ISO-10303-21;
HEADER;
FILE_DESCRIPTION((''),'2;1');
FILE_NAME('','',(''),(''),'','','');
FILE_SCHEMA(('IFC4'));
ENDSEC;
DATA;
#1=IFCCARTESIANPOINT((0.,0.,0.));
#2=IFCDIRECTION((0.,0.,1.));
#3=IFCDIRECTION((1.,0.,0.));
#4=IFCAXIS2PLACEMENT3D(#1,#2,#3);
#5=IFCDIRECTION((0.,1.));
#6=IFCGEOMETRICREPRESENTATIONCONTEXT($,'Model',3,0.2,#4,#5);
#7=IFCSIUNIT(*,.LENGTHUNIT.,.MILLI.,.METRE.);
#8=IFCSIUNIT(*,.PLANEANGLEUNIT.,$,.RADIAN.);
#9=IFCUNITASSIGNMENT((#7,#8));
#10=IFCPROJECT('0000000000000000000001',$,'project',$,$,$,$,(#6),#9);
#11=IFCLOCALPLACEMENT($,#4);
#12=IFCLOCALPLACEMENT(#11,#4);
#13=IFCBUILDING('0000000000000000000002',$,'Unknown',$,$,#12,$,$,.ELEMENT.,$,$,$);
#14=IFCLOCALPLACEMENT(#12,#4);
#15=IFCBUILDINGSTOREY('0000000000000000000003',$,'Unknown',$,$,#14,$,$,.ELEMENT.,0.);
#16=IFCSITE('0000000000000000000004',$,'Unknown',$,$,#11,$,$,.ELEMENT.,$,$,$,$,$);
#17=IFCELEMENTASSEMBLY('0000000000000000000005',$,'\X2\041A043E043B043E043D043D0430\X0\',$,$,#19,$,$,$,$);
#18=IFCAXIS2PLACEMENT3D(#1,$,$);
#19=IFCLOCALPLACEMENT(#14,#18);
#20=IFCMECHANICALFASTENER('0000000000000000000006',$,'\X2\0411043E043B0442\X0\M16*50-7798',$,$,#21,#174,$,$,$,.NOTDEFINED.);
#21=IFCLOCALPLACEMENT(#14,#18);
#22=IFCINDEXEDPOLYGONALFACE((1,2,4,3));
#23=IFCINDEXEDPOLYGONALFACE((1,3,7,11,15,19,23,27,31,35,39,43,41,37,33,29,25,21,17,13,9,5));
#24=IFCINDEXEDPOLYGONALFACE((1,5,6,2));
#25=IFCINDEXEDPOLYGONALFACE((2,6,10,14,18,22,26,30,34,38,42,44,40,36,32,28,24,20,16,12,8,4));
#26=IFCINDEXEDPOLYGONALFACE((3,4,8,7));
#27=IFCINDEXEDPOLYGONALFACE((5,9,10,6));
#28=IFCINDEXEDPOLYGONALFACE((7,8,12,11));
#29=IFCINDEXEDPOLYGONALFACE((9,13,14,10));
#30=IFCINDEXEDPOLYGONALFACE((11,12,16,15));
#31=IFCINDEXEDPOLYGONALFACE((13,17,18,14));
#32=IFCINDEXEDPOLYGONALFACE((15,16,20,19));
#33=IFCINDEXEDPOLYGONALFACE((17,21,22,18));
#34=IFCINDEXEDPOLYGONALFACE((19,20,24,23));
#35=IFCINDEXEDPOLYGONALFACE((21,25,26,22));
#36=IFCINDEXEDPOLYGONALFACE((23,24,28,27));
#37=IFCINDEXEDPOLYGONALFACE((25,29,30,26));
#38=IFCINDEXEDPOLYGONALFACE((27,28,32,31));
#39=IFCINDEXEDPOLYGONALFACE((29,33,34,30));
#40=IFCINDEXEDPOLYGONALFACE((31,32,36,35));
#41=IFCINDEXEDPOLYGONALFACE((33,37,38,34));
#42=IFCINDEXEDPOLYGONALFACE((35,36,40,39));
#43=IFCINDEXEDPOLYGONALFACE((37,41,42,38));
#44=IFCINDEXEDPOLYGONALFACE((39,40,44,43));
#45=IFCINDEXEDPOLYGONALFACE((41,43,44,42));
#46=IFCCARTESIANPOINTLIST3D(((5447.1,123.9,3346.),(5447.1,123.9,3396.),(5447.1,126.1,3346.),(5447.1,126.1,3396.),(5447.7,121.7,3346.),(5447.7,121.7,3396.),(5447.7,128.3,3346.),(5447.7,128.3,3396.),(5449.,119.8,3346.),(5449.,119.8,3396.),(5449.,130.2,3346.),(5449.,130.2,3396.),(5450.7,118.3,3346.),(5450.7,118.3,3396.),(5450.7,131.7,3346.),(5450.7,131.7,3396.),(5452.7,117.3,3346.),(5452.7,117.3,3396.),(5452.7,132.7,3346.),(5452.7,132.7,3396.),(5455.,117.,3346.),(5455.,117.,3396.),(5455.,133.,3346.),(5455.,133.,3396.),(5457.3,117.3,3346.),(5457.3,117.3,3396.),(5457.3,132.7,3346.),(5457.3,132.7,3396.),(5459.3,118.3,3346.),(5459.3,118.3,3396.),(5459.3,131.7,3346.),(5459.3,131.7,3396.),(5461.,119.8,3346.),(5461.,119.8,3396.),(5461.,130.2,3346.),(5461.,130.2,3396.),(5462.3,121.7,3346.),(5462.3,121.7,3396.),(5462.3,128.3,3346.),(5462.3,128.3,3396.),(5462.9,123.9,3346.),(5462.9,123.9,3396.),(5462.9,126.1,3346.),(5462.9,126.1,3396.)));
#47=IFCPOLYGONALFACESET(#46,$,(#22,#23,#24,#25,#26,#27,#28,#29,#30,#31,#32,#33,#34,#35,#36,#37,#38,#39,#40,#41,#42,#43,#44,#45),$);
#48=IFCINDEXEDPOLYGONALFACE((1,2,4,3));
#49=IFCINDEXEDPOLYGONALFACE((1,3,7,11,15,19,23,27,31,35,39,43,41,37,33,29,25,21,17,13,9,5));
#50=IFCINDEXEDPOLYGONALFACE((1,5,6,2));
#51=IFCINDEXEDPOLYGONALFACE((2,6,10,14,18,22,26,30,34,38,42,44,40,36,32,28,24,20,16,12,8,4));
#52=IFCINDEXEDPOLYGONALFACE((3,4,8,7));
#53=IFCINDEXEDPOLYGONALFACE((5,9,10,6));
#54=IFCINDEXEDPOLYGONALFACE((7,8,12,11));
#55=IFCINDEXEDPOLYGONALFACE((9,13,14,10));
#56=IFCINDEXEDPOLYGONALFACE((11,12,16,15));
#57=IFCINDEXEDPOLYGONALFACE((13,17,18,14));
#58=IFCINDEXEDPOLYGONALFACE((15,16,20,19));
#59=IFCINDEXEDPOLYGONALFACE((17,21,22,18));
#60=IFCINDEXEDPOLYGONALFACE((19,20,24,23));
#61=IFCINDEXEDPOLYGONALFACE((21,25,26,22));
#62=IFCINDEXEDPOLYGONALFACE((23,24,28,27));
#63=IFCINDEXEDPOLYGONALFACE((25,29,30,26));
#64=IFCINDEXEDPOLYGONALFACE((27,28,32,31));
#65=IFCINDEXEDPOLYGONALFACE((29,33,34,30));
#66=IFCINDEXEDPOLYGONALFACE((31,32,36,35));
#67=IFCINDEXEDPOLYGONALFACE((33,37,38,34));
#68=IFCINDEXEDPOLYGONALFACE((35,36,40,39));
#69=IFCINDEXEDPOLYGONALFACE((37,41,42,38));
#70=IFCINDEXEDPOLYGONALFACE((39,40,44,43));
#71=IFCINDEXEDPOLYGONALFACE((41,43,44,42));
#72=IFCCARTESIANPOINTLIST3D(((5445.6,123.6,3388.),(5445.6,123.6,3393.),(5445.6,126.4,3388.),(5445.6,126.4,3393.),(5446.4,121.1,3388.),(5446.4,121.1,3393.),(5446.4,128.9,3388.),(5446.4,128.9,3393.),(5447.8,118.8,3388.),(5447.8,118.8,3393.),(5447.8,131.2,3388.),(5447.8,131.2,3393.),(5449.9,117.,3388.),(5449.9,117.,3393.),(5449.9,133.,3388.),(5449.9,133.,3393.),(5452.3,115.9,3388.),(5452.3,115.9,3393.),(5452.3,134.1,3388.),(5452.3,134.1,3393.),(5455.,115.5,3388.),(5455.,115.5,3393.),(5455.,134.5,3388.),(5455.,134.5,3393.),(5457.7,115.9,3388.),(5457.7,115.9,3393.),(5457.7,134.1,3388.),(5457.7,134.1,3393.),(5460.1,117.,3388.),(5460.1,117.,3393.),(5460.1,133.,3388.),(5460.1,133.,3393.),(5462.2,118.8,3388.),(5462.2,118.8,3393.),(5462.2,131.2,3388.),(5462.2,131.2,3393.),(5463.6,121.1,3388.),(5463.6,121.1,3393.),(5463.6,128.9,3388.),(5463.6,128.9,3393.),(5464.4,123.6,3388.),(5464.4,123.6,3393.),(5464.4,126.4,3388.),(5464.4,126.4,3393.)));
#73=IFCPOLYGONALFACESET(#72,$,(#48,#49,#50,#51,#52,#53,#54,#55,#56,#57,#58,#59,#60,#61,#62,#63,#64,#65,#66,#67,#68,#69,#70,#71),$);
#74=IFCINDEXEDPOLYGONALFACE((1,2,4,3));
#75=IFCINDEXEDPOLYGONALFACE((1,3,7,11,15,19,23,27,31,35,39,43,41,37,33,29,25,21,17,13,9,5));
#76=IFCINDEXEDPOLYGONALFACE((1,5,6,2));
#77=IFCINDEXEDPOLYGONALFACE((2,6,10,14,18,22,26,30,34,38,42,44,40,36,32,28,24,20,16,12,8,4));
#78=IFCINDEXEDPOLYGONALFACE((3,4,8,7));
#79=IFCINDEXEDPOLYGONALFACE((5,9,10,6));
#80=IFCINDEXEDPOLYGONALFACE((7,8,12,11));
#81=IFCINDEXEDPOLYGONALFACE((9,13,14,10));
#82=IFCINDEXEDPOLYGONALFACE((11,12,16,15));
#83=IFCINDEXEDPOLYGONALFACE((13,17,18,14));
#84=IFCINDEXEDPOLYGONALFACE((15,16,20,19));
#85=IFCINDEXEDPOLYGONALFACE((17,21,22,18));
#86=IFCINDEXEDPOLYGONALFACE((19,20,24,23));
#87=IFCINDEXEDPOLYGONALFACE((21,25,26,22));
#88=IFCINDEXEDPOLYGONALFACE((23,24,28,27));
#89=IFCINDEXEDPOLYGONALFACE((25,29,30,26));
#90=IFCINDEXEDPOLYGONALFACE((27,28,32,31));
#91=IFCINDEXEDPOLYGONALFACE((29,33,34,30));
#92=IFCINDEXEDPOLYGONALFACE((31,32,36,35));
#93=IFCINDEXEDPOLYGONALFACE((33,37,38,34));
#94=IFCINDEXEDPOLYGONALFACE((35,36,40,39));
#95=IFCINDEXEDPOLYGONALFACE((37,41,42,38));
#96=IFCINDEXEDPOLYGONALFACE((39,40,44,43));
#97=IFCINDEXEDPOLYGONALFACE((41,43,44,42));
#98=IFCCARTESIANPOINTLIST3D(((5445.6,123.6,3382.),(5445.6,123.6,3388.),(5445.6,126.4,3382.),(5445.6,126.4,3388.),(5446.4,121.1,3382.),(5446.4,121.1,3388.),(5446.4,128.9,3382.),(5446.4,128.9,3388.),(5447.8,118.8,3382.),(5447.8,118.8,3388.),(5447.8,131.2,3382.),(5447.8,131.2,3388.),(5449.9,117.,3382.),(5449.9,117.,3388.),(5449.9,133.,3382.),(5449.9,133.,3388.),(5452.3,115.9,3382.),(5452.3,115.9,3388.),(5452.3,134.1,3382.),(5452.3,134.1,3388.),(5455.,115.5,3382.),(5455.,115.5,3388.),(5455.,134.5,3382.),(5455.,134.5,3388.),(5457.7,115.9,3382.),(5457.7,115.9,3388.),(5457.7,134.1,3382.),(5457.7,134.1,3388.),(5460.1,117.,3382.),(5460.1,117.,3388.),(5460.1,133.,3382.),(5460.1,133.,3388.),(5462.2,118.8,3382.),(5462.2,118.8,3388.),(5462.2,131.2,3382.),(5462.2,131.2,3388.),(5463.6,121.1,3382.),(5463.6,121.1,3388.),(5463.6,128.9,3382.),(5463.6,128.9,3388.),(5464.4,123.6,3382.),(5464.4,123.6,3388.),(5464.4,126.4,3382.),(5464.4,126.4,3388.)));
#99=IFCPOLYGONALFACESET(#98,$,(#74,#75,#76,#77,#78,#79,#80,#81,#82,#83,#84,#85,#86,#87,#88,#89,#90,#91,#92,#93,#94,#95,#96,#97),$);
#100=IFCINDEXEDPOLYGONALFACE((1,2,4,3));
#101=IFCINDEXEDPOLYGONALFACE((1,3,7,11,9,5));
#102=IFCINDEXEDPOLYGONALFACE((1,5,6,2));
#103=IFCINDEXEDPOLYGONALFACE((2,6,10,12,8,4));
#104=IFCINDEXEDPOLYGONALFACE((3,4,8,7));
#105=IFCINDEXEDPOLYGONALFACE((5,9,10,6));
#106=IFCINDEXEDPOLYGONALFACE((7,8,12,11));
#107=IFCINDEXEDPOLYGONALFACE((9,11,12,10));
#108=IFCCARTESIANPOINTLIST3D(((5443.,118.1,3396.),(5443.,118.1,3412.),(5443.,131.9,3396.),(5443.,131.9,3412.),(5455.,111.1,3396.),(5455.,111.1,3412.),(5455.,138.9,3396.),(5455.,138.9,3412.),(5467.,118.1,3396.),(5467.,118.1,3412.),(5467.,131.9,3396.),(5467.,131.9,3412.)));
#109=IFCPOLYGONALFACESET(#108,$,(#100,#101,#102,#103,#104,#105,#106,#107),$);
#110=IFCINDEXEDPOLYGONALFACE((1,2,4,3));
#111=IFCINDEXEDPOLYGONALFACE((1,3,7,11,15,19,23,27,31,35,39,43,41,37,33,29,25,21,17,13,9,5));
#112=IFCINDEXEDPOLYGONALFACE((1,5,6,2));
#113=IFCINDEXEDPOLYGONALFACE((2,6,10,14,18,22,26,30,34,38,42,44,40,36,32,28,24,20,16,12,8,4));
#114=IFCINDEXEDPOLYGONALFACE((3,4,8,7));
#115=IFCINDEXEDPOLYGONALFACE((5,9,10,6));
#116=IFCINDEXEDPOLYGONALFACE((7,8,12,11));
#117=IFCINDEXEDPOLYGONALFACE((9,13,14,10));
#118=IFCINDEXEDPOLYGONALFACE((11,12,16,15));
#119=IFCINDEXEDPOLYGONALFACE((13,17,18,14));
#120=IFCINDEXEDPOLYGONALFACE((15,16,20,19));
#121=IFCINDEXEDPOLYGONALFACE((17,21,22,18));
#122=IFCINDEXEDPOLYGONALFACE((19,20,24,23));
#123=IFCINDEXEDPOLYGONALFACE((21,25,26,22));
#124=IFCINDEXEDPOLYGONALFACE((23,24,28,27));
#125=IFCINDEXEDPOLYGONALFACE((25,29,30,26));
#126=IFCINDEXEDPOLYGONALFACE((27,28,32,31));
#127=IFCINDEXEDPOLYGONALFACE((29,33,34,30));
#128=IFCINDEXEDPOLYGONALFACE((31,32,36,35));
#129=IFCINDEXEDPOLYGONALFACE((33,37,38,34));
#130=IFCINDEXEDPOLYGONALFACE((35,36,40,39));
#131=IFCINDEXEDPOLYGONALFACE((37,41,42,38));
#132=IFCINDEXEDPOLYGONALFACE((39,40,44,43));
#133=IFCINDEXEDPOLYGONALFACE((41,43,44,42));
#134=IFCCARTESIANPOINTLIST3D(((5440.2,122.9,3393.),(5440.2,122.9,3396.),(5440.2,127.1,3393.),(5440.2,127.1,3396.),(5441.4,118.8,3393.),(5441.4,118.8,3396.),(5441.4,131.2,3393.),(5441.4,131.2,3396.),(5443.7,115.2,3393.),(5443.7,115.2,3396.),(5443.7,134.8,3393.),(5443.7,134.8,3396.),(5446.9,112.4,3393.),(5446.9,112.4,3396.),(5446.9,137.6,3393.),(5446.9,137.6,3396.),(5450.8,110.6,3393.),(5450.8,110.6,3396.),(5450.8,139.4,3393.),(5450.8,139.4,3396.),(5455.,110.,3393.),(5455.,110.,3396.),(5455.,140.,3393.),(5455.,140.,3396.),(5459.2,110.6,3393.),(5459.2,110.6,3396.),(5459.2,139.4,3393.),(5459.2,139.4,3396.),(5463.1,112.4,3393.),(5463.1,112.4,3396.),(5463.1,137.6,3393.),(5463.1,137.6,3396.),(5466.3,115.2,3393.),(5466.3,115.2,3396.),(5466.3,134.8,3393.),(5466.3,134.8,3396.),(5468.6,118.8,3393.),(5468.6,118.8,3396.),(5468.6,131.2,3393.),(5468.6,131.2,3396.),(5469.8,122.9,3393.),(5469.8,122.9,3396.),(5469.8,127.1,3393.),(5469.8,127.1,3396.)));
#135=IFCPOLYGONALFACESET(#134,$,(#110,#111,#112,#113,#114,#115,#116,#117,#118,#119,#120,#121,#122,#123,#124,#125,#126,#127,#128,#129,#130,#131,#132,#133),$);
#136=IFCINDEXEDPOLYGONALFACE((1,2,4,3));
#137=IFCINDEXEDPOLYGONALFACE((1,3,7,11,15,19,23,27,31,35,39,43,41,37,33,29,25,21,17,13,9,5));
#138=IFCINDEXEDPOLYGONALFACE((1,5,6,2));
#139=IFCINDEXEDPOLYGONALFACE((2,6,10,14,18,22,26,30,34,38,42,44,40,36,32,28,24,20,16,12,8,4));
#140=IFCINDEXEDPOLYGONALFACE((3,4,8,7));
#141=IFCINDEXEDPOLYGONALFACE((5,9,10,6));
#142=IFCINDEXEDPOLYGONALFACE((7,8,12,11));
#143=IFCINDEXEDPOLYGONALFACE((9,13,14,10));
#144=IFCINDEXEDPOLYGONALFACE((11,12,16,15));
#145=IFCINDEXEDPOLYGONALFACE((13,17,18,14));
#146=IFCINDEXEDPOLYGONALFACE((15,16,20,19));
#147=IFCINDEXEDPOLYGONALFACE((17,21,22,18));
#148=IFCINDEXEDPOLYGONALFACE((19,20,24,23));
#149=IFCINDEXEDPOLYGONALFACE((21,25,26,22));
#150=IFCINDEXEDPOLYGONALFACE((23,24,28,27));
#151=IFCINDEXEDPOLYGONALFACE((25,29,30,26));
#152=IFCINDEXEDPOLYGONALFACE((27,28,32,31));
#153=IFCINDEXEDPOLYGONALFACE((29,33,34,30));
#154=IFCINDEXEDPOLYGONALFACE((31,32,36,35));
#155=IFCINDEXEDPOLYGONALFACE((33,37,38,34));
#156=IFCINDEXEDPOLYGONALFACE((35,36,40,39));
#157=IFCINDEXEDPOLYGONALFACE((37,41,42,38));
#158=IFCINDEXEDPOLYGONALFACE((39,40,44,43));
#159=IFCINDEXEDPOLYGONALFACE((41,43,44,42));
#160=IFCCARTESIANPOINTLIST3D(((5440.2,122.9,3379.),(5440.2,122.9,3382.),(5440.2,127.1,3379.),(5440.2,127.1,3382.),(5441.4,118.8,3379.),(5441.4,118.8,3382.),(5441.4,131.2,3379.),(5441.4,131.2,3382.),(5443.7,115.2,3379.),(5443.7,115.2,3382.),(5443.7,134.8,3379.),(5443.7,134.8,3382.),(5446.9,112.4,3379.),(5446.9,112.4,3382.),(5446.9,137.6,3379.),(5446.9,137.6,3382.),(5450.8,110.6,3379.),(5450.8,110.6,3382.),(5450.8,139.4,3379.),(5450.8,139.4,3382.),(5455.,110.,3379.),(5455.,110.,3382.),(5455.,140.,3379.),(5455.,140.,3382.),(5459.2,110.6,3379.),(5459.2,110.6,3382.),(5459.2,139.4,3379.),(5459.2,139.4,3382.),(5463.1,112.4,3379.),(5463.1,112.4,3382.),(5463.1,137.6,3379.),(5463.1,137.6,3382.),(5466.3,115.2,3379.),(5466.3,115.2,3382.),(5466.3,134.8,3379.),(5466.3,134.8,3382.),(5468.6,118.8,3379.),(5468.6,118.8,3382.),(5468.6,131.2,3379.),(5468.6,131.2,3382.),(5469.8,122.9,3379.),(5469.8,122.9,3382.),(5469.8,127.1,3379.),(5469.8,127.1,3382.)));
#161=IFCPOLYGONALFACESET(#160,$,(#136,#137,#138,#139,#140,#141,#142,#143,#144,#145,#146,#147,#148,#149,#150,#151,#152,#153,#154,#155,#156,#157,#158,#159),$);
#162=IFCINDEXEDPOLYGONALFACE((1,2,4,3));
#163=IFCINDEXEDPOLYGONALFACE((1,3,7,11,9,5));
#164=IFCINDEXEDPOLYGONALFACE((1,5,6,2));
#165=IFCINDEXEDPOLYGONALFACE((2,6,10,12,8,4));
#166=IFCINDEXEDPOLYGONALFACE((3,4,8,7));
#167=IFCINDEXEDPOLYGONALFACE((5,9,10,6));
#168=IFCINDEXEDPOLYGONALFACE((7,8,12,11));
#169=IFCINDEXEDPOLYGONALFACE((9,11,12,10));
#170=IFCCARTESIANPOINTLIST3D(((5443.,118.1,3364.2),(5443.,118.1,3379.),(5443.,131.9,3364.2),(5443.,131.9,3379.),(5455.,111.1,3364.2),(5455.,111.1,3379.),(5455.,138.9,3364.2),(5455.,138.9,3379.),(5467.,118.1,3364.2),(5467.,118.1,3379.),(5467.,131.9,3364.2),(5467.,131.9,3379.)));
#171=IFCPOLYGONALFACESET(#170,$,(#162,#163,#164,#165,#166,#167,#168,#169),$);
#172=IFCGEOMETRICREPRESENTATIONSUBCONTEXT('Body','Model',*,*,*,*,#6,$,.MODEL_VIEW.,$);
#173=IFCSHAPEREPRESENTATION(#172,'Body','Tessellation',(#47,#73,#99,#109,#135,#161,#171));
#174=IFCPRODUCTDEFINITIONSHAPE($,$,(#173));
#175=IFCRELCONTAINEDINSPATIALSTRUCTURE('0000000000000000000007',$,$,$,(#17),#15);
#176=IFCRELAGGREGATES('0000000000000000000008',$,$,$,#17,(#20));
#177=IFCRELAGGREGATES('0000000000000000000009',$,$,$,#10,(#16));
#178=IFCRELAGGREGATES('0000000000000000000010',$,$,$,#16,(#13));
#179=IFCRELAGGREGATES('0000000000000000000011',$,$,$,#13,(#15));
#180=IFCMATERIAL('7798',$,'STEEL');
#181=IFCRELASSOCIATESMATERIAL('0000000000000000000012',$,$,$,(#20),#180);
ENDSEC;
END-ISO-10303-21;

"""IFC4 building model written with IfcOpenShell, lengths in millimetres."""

from ifc_helpers import new_model, si_unit, direction, frame, origin_with_axes, place, context, subcontext, project, spatial, line, arc, indexed_curve, outline, extrude, source, transform, mapped, material, element, aggregate, save


model = new_model("IFC4")

# Units and contexts
model_context = context("Model", 3, precision=0.2, world=origin_with_axes(), true_north=direction((0.0, 1.0)))
body_context = subcontext(model_context, "Body", "Model", "MODEL_VIEW")
ifc_project = project(units=[si_unit("LENGTHUNIT", "METRE", prefix="MILLI"), si_unit("PLANEANGLEUNIT", "RADIAN")], contexts=[model_context])

# Site, building, storey
site_placement = place(None, origin_with_axes())
site = spatial("IfcSite", under=ifc_project, at=site_placement, Name="Unknown", CompositionType="ELEMENT")
building_placement = place(site_placement, origin_with_axes())
building = spatial("IfcBuilding", under=site, at=building_placement, Name="Unknown", CompositionType="ELEMENT")
storey_placement = place(building_placement, origin_with_axes())
storey = spatial("IfcBuildingStorey", under=building, at=storey_placement, Name="Unknown", CompositionType="ELEMENT", Elevation=0.0)

# Element assembly
assembly_1_placement = place(storey_placement, frame((5400.0, 0.0, -40.0), z_axis=(-1.0, 0.0, 0.0), x_axis=(0.0, 0.0, 1.0)))
assembly_1 = element("IfcElementAssembly", 1, at=assembly_1_placement, inside=storey, Name="Колонна")

# Mechanical fastener
ifc_material_1 = material(Name="7798", Category="STEEL")
shared_shape_1 = source(origin_with_axes(), body_context, "Body", "SweptSolid", [
    extrude(outline(indexed_curve([(8.0, 0.0), (0.0, 8.0), (-8.0, 0.0), (0.0, -8.0)], segments=[arc(1, 2, 3), arc(3, 4, 1)])), frame((0.0, 0.0, 8.0), z_axis=(0.0, 0.0, -1.0), x_axis=(0.0, 1.0, 0.0)), (0.0, 0.0, 1.0), 50.0),
    extrude(outline(indexed_curve([(9.5, 0.0), (0.0, 9.5), (-9.5, 0.0), (0.0, -9.5)], segments=[arc(1, 2, 3), arc(3, 4, 1)])), frame((0.0, 0.0, 5.0), z_axis=(0.0, 0.0, -1.0), x_axis=(0.0, 1.0, 0.0)), (0.0, 0.0, 1.0), 5.0),
    extrude(outline(indexed_curve([(9.5, 0.0), (0.0, 9.5), (-9.5, 0.0), (0.0, -9.5)], segments=[arc(1, 2, 3), arc(3, 4, 1)])), frame((0.0, 0.0, 0.0), z_axis=(0.0, 0.0, -1.0), x_axis=(0.0, 1.0, 0.0)), (0.0, 0.0, 1.0), 6.0),
    extrude(outline(indexed_curve([(13.9, 0.0), (6.9, 12.0), (-6.9, 12.0), (-13.9, 0.0), (-6.9, -12.0), (6.9, -12.0)], segments=[line(1, 2, 3, 4, 5, 6, 1)])), frame((0.0, 0.0, 24.0), z_axis=(0.0, 0.0, -1.0), x_axis=(0.0, 1.0, 0.0)), (0.0, 0.0, 1.0), 16.0),
    extrude(outline(indexed_curve([(15.0, 0.0), (0.0, 15.0), (-15.0, 0.0), (0.0, -15.0)], segments=[arc(1, 2, 3), arc(3, 4, 1)])), frame((0.0, 0.0, 8.0), z_axis=(0.0, 0.0, -1.0), x_axis=(0.0, 1.0, 0.0)), (0.0, 0.0, 1.0), 3.0),
    extrude(outline(indexed_curve([(15.0, 0.0), (0.0, 15.0), (-15.0, 0.0), (0.0, -15.0)], segments=[arc(1, 2, 3), arc(3, 4, 1)])), frame((0.0, 0.0, -6.0), z_axis=(0.0, 0.0, -1.0), x_axis=(0.0, 1.0, 0.0)), (0.0, 0.0, 1.0), 3.0),
    extrude(outline(indexed_curve([(13.9, 0.0), (6.9, 12.0), (-6.9, 12.0), (-13.9, 0.0), (-6.9, -12.0), (6.9, -12.0)], segments=[line(1, 2, 3, 4, 5, 6, 1)])), frame((0.0, 0.0, -9.0), z_axis=(0.0, 0.0, -1.0), x_axis=(0.0, 1.0, 0.0)), (0.0, 0.0, 1.0), 14.8),
])
mechanical_fastener_1_placement = place(assembly_1_placement, frame((3428.0, 125.0, -55.0), z_axis=(1.0, 0.0, 0.0), x_axis=(0.0, 0.0, 1.0)))
mechanical_fastener_1 = element("IfcMechanicalFastener", 2, at=mechanical_fastener_1_placement, material=ifc_material_1, Name="БолтM16*50-7798", PredefinedType="NOTDEFINED", context=body_context, shape_type="MappedRepresentation", body=[
    mapped(shared_shape_1, transform((0.0, 0.0, 0.0))),
])
aggregate(assembly_1, [mechanical_fastener_1])

save(model, "model.ifc")
